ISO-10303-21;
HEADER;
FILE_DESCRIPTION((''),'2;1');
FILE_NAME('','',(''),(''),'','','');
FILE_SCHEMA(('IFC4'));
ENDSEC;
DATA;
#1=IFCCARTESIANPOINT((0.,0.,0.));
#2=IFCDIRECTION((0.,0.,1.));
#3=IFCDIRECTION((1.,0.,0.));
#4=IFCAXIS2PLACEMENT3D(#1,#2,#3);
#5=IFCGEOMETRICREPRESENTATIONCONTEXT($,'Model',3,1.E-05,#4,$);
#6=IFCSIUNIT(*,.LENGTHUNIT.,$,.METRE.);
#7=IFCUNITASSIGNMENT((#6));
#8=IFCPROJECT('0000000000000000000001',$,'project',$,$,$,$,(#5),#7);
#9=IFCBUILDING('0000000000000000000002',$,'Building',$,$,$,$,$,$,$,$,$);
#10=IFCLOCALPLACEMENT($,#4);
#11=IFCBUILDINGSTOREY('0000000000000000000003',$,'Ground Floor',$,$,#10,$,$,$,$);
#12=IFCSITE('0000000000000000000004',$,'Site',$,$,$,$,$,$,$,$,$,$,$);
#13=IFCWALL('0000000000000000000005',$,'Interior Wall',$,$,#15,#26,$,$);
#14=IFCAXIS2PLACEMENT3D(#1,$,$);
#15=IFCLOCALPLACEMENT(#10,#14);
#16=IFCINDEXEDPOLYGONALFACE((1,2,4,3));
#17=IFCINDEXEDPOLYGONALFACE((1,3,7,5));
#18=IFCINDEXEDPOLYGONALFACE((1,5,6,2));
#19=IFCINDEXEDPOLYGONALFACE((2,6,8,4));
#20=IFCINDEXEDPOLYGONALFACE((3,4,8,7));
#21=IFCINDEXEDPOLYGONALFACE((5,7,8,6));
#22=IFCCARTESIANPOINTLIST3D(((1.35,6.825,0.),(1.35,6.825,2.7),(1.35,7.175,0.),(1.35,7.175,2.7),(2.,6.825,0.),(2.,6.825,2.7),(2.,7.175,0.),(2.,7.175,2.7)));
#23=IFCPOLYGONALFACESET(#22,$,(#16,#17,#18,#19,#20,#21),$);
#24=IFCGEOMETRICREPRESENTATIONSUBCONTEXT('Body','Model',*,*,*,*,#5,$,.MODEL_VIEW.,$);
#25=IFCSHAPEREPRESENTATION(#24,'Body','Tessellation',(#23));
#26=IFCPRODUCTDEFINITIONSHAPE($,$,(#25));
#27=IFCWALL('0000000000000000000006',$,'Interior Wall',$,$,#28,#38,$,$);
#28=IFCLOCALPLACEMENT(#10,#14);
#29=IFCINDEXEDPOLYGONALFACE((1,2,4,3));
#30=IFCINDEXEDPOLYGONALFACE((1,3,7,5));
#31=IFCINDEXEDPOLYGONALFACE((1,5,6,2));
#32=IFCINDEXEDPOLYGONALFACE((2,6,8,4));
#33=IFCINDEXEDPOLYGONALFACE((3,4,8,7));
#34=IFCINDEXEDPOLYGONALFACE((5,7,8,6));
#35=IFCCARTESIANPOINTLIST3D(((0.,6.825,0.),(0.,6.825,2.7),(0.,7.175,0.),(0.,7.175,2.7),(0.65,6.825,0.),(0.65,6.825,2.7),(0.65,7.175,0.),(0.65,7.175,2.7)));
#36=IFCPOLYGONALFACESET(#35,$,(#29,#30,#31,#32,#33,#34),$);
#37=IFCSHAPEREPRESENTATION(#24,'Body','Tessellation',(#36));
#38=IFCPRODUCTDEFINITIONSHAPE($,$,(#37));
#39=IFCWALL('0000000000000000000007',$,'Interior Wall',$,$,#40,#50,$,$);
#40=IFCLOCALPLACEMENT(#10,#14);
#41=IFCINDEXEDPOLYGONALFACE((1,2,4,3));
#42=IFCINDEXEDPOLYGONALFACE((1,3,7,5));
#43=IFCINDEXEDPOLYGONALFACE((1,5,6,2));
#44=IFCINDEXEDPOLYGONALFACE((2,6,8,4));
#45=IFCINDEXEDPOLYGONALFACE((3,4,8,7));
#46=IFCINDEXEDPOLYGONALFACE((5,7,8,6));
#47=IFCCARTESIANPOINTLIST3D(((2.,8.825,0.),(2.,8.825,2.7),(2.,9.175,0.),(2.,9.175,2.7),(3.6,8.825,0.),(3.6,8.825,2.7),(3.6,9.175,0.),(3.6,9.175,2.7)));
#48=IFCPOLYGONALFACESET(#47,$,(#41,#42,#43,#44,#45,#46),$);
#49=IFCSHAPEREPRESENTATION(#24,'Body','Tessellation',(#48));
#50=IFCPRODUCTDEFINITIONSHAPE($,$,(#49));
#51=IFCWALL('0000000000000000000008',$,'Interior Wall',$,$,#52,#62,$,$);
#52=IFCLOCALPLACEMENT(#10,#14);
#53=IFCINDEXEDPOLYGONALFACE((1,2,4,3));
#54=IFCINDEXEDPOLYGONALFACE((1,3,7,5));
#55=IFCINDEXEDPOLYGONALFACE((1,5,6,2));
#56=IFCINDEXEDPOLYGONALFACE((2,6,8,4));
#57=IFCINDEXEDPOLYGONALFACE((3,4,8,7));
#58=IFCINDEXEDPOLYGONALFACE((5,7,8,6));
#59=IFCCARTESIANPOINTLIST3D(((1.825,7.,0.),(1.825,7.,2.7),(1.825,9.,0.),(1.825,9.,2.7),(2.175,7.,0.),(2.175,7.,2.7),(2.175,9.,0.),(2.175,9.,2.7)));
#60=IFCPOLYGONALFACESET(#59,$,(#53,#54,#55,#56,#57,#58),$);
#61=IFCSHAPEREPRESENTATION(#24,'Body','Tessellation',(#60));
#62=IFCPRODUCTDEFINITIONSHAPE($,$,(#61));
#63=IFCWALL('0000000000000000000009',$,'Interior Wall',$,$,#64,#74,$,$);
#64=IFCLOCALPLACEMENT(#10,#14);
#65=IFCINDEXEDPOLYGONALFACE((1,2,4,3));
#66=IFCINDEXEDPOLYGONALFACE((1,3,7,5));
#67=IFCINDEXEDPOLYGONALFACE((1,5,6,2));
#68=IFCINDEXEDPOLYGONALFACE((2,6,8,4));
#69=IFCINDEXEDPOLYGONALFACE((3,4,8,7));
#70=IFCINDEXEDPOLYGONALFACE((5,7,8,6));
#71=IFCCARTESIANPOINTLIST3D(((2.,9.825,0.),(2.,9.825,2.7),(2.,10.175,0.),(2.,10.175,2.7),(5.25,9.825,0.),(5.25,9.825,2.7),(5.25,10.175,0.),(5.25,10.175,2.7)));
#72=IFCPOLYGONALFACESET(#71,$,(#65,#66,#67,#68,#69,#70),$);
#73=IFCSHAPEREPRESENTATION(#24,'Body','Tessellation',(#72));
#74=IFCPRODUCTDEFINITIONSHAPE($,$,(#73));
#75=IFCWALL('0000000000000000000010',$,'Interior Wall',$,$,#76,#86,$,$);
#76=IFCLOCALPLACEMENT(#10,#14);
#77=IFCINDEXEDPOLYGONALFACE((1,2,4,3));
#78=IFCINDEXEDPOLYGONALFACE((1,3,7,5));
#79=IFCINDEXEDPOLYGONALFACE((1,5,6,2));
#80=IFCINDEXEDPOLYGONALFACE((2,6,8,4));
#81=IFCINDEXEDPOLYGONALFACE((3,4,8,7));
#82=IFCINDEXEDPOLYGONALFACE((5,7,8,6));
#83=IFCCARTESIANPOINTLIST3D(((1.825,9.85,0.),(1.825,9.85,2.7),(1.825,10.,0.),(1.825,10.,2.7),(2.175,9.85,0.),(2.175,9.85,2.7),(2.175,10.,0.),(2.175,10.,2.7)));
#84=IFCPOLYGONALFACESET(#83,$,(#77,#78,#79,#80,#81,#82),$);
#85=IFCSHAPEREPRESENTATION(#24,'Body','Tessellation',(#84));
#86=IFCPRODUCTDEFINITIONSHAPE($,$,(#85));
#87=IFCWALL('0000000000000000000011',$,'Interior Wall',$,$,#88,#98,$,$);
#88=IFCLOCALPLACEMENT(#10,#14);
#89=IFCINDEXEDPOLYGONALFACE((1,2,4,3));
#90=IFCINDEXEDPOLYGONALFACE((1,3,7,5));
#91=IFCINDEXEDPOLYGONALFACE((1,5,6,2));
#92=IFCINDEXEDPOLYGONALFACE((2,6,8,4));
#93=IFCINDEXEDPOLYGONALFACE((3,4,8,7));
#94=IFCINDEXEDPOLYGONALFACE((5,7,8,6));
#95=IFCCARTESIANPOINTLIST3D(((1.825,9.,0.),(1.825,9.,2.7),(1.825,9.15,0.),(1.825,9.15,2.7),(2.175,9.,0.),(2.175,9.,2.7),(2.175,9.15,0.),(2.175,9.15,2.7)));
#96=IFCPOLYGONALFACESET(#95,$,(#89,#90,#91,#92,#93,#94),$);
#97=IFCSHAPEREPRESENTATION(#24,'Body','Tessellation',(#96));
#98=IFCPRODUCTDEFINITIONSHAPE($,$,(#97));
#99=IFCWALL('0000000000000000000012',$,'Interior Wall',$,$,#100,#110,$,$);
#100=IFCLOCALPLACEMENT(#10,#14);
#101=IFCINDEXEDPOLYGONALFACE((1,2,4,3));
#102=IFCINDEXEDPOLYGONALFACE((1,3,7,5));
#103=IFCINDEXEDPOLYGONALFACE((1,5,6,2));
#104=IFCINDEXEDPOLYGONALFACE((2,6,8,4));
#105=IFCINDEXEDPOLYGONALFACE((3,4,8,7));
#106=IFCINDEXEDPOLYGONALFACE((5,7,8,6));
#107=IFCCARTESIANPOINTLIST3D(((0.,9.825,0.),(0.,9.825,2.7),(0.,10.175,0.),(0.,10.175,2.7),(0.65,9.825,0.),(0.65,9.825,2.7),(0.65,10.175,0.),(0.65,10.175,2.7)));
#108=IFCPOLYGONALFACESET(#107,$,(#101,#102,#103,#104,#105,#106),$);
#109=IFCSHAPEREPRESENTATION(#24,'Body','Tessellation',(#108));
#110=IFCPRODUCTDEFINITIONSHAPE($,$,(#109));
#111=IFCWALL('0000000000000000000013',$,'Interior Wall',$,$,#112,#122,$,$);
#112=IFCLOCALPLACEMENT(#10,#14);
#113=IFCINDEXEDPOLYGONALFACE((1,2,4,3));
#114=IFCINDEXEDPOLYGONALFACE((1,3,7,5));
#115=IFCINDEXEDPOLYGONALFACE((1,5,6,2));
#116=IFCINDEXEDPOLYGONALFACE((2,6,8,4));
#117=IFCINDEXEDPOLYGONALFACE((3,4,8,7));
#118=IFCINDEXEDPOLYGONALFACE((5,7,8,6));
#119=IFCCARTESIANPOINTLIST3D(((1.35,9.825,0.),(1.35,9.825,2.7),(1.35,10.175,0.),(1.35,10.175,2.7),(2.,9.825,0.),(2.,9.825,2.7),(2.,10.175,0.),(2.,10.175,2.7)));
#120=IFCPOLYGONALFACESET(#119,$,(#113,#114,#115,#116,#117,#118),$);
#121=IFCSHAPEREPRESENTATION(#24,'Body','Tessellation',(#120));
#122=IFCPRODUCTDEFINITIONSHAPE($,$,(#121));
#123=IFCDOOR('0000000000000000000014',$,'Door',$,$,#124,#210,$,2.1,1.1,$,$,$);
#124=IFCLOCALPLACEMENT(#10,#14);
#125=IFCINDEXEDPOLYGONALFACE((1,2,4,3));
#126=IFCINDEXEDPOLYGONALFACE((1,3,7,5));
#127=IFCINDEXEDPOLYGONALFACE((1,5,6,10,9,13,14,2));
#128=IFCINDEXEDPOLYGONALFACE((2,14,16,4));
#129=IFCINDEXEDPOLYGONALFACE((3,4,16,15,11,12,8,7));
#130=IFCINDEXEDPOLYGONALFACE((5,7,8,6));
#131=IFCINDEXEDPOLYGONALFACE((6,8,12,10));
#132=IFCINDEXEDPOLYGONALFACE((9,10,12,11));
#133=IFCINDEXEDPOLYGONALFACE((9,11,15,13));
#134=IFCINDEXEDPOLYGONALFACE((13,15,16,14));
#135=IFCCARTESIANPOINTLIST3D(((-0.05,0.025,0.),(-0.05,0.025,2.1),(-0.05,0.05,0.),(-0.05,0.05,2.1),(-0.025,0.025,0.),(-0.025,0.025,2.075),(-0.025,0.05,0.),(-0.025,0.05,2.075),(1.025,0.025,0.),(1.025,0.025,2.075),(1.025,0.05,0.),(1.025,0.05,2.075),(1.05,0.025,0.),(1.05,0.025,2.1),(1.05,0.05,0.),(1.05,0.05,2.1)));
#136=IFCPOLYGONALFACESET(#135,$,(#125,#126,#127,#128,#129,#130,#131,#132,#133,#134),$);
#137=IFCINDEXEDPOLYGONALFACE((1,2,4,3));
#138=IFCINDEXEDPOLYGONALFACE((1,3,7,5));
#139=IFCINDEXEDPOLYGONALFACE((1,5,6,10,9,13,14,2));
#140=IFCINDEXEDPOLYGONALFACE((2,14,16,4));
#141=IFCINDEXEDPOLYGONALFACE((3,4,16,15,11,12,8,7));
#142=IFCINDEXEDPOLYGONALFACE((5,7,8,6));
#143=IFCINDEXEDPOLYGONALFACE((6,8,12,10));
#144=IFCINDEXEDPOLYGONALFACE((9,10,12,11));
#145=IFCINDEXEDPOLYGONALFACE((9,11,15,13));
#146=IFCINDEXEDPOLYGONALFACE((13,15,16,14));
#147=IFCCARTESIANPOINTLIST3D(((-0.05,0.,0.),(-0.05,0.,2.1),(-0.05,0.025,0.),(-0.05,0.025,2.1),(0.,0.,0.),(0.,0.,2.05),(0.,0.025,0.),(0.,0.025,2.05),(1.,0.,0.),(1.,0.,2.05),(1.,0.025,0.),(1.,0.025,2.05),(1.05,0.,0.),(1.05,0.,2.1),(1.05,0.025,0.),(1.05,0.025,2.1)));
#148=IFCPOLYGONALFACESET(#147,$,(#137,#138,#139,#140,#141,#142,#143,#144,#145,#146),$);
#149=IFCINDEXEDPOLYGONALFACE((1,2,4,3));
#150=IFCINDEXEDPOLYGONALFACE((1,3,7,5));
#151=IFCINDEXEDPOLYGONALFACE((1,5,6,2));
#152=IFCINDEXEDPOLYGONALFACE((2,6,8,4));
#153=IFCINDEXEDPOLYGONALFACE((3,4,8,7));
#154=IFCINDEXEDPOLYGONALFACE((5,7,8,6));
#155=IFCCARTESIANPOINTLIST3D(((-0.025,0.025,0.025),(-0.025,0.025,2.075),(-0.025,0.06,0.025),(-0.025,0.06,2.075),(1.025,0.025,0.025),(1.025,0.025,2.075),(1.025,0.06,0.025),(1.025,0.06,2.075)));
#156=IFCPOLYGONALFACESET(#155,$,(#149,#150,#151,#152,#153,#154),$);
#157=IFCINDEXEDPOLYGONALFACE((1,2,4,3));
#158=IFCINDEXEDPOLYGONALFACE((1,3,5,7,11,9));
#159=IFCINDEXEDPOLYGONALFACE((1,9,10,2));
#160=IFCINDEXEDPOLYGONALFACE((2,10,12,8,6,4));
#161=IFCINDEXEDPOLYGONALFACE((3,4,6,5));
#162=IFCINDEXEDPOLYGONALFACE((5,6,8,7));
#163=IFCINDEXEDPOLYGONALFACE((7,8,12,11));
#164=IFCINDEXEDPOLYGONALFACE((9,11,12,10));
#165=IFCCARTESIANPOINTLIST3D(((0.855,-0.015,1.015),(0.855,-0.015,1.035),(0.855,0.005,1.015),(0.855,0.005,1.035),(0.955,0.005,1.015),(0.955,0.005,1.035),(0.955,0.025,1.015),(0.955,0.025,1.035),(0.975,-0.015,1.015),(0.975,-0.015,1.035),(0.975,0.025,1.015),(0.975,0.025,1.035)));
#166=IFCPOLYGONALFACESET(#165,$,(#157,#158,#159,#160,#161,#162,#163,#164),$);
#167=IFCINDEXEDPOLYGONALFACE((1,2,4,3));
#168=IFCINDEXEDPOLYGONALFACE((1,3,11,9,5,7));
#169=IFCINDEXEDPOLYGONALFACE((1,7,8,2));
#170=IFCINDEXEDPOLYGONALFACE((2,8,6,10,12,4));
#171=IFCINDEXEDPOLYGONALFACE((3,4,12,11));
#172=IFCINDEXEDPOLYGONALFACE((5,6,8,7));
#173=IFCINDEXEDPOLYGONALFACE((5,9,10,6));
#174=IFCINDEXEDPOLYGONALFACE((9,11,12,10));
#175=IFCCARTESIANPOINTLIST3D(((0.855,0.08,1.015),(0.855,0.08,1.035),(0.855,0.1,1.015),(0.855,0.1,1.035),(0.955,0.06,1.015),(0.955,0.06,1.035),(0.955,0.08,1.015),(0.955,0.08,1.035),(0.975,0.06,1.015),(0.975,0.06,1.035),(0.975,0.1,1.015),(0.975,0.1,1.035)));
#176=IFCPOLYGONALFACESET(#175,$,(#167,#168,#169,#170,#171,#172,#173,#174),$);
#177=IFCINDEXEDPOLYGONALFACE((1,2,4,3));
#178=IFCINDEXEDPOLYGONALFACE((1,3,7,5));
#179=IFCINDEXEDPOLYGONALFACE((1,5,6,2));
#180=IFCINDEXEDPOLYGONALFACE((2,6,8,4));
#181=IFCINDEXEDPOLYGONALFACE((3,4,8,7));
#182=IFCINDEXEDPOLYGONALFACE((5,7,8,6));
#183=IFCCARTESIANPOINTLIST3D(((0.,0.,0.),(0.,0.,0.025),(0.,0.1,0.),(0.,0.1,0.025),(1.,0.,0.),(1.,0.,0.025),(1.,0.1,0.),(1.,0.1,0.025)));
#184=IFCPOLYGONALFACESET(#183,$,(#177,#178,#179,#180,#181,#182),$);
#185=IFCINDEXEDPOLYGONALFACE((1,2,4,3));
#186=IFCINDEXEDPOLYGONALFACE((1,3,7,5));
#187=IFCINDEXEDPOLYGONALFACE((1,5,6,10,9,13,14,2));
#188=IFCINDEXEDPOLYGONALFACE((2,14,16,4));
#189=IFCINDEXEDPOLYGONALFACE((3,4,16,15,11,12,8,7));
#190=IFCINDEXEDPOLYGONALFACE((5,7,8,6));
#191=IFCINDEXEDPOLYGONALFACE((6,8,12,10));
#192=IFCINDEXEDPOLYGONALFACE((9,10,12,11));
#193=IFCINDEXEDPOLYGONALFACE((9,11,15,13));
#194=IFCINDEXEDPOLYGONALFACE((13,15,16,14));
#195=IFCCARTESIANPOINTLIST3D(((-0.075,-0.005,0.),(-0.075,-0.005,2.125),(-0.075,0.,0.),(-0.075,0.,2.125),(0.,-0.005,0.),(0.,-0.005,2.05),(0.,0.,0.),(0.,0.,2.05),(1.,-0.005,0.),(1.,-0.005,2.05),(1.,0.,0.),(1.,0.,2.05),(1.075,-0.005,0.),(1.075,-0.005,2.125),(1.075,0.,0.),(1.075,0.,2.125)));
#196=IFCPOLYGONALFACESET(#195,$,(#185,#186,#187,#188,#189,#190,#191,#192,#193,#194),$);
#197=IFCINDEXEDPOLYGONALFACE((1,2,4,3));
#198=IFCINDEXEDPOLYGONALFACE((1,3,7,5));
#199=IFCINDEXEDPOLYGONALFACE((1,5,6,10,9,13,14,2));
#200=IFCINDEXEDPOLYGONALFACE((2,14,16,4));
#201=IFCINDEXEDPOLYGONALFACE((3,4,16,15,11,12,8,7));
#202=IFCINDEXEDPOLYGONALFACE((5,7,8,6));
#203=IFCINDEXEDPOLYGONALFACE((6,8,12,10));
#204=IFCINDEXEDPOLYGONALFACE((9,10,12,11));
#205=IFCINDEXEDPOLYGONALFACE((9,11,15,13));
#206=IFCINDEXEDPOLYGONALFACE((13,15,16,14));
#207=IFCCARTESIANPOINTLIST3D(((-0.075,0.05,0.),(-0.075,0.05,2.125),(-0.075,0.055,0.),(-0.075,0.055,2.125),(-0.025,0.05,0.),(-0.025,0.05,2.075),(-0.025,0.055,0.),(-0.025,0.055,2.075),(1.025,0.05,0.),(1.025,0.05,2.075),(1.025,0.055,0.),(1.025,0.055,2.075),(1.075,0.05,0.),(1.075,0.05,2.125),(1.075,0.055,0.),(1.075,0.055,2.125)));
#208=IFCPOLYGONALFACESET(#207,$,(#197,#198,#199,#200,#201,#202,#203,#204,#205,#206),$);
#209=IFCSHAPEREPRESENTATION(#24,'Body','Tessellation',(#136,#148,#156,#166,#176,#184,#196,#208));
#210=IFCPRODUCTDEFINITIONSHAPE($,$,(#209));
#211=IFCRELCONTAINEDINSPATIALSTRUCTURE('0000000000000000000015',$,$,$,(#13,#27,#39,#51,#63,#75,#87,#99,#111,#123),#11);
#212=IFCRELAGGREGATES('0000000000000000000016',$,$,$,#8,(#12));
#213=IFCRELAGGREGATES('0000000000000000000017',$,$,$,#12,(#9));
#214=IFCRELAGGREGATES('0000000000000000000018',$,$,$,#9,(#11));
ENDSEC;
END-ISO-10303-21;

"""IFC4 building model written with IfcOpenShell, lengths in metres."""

from ifc_helpers import new_model, si_unit, frame, origin_with_axes, place, context, subcontext, project, spatial, line, indexed_curve, outline, extrude, element, save


model = new_model("IFC4")

# Units and contexts
model_context = context("Model", 3, precision=1e-05, world=origin_with_axes())
body_context = subcontext(model_context, "Body", "Model", "MODEL_VIEW")
ifc_project = project(units=[si_unit("LENGTHUNIT", "METRE")], contexts=[model_context])

# Site, building, storey
site = spatial("IfcSite", under=ifc_project, Name="Site")
building = spatial("IfcBuilding", under=site, Name="Building")
storey_placement = place(None, origin_with_axes())
storey = spatial("IfcBuildingStorey", under=building, at=storey_placement, Name="Ground Floor")

# Walls
for number, where, z_axis, x_axis, name in (
    (1, (2.0, 7.0, 0.0), (0.0, 0.0, 1.0), (-1.0, 0.0, 0.0), "Interior Wall"),
    (2, (0.65, 7.0, 0.0), (0.0, 0.0, 1.0), (-1.0, 0.0, 0.0), "Interior Wall"),
):
    element("IfcWall", number, at=place(storey_placement, frame(where, z_axis=z_axis, x_axis=x_axis)), inside=storey, Name=name, context=body_context, shape_type="SweptSolid", body=[
        extrude(outline(indexed_curve([(0.0, 0.0), (0.0, 0.35), (0.65, 0.35), (0.65, 0.0), (0.0, 0.0)], self_intersect=False)), frame((0.0, -0.175, 0.0), z_axis=(0.0, 0.0, 1.0), x_axis=(1.0, 0.0, 0.0)), (0.0, 0.0, 1.0), 2.7),
    ])
wall_1_placement = place(storey_placement, frame((3.6, 9.0, 0.0), z_axis=(0.0, 0.0, 1.0), x_axis=(-1.0, 0.0, 0.0)))
element("IfcWall", 3, at=wall_1_placement, inside=storey, Name="Interior Wall", context=body_context, shape_type="SweptSolid", body=[
    extrude(outline(indexed_curve([(0.0, 0.0), (0.0, 0.35), (1.6, 0.35), (1.6, 0.0), (0.0, 0.0)], self_intersect=False)), frame((0.0, -0.175, 0.0), z_axis=(0.0, 0.0, 1.0), x_axis=(1.0, 0.0, 0.0)), (0.0, 0.0, 1.0), 2.7),
])
wall_2_placement = place(storey_placement, frame((2.0, 9.0, 0.0), z_axis=(0.0, 0.0, 1.0), x_axis=(0.0, -1.0, 0.0)))
element("IfcWall", 4, at=wall_2_placement, inside=storey, Name="Interior Wall", context=body_context, shape_type="SweptSolid", body=[
    extrude(outline(indexed_curve([(0.0, 0.0), (0.0, 0.35), (2.0, 0.35), (2.0, 0.0), (0.0, 0.0)], self_intersect=False)), frame((0.0, -0.175, 0.0), z_axis=(0.0, 0.0, 1.0), x_axis=(1.0, 0.0, 0.0)), (0.0, 0.0, 1.0), 2.7),
])
wall_3_placement = place(storey_placement, frame((5.25, 10.0, 0.0), z_axis=(0.0, 0.0, 1.0), x_axis=(-1.0, 0.0, 0.0)))
element("IfcWall", 5, at=wall_3_placement, inside=storey, Name="Interior Wall", context=body_context, shape_type="SweptSolid", body=[
    extrude(outline(indexed_curve([(0.0, 0.0), (0.0, 0.35), (3.25, 0.35), (3.25, 0.0), (0.0, 0.0)], self_intersect=False)), frame((0.0, -0.175, 0.0), z_axis=(0.0, 0.0, 1.0), x_axis=(1.0, 0.0, 0.0)), (0.0, 0.0, 1.0), 2.7),
])
for number, where, z_axis, x_axis, name in (
    (6, (2.0, 10.0, 0.0), (0.0, 0.0, 1.0), (0.0, -1.0, 0.0), "Interior Wall"),
    (7, (2.0, 9.15, 0.0), (0.0, 0.0, 1.0), (0.0, -1.0, 0.0), "Interior Wall"),
):
    element("IfcWall", number, at=place(storey_placement, frame(where, z_axis=z_axis, x_axis=x_axis)), inside=storey, Name=name, context=body_context, shape_type="SweptSolid", body=[
        extrude(outline(indexed_curve([(0.0, 0.0), (0.0, 0.35), (0.15, 0.35), (0.15, 0.0), (0.0, 0.0)], self_intersect=False)), frame((0.0, -0.175, 0.0), z_axis=(0.0, 0.0, 1.0), x_axis=(1.0, 0.0, 0.0)), (0.0, 0.0, 1.0), 2.7),
    ])
wall_4_placement = place(storey_placement, frame((0.0, 10.0, 0.0), z_axis=(0.0, 0.0, 1.0), x_axis=(1.0, 0.0, 0.0)))
element("IfcWall", 8, at=wall_4_placement, inside=storey, Name="Interior Wall", context=body_context, shape_type="SweptSolid", body=[
    extrude(outline(indexed_curve([(0.0, 0.0), (0.0, 0.35), (0.65, 0.35), (0.65, 0.0), (0.0, 0.0)], self_intersect=False)), frame((0.0, -0.175, 0.0), z_axis=(0.0, 0.0, 1.0), x_axis=(1.0, 0.0, 0.0)), (0.0, 0.0, 1.0), 2.7),
])
wall_5_placement = place(storey_placement, frame((1.35, 10.0, 0.0), z_axis=(0.0, 0.0, 1.0), x_axis=(1.0, 0.0, 0.0)))
element("IfcWall", 9, at=wall_5_placement, inside=storey, Name="Interior Wall", context=body_context, shape_type="SweptSolid", body=[
    extrude(outline(indexed_curve([(0.0, 0.0), (0.0, 0.35), (0.65, 0.35), (0.65, 0.0), (0.0, 0.0)], self_intersect=False)), frame((0.0, -0.175, 0.0), z_axis=(0.0, 0.0, 1.0), x_axis=(1.0, 0.0, 0.0)), (0.0, 0.0, 1.0), 2.7),
])

# Door
door_1_placement = place(storey_placement, frame((-0.05, 0.0, 0.0), z_axis=(0.0, 0.0, 1.0), x_axis=(1.0, 0.0, 0.0)))
element("IfcDoor", 10, at=door_1_placement, inside=storey, Name="Door", OverallHeight=2.1, OverallWidth=1.1, context=body_context, shape_type="SweptSolid", body=[
    extrude(outline(indexed_curve([(0.0, 0.0), (0.0, 2.1), (1.1, 2.1), (1.1, 0.0), (1.075, 0.0), (1.075, 2.075), (0.025, 2.075), (0.025, 0.0)], segments=[line(1, 2, 3, 4, 5, 6, 7, 8, 1)])), frame((0.0, 0.025, 0.0), z_axis=(0.0, -1.0, 0.0), x_axis=(1.0, 0.0, 0.0)), (0.0, 0.0, -1.0), 0.025),
    extrude(outline(indexed_curve([(0.0, 0.0), (0.0, 2.1), (1.1, 2.1), (1.1, 0.0), (1.05, 0.0), (1.05, 2.05), (0.05, 2.05), (0.05, 0.0)], segments=[line(1, 2, 3, 4, 5, 6, 7, 8, 1)])), frame((0.0, 0.0, 0.0), z_axis=(0.0, -1.0, 0.0), x_axis=(1.0, 0.0, 0.0)), (0.0, 0.0, -1.0), 0.025),
    extrude(outline(indexed_curve([(0.0, 0.0), (1.05, 0.0), (1.05, 0.035), (0.0, 0.035)], segments=[line(1, 2, 3, 4, 1)])), frame((0.025, 0.025, 0.025), z_axis=(0.0, 0.0, 1.0), x_axis=(1.0, 0.0, 0.0)), (0.0, 0.0, 1.0), 2.05),
    extrude(outline(indexed_curve([(0.0, 0.0), (0.0, -0.04), (-0.12, -0.04), (-0.12, -0.02), (-0.02, -0.02), (-0.02, 0.0)], segments=[line(1, 2, 3, 4, 5, 6, 1)])), frame((1.025, 0.025, 1.015), z_axis=(0.0, 0.0, 1.0), x_axis=(1.0, 0.0, 0.0)), (0.0, 0.0, 1.0), 0.02),
    extrude(outline(indexed_curve([(0.0, 0.0), (0.0, 0.04), (-0.12, 0.04), (-0.12, 0.02), (-0.02, 0.02), (-0.02, 0.0)], segments=[line(1, 2, 3, 4, 5, 6, 1)])), frame((1.025, 0.06, 1.015), z_axis=(0.0, 0.0, 1.0), x_axis=(1.0, 0.0, 0.0)), (0.0, 0.0, 1.0), 0.02),
    extrude(outline(indexed_curve([(0.0, 0.0), (1.0, 0.0), (1.0, 0.1), (0.0, 0.1)], segments=[line(1, 2, 3, 4, 1)])), frame((0.05, 0.0, 0.0), z_axis=(0.0, 0.0, 1.0), x_axis=(1.0, 0.0, 0.0)), (0.0, 0.0, 1.0), 0.025),
    extrude(outline(indexed_curve([(0.0, 0.0), (0.0, 2.125), (1.15, 2.125), (1.15, 0.0), (1.075, 0.0), (1.075, 2.05), (0.075, 2.05), (0.075, 0.0)], segments=[line(1, 2, 3, 4, 5, 6, 7, 8, 1)])), frame((-0.025, -0.005, 0.0), z_axis=(0.0, -1.0, 0.0), x_axis=(1.0, 0.0, 0.0)), (0.0, 0.0, -1.0), 0.005),
    extrude(outline(indexed_curve([(0.0, 0.0), (0.0, 2.125), (1.15, 2.125), (1.15, 0.0), (1.1, 0.0), (1.1, 2.075), (0.05, 2.075), (0.05, 0.0)], segments=[line(1, 2, 3, 4, 5, 6, 7, 8, 1)])), frame((-0.025, 0.05, 0.0), z_axis=(0.0, -1.0, 0.0), x_axis=(1.0, 0.0, 0.0)), (0.0, 0.0, -1.0), 0.005),
])

save(model, "model.ifc")
